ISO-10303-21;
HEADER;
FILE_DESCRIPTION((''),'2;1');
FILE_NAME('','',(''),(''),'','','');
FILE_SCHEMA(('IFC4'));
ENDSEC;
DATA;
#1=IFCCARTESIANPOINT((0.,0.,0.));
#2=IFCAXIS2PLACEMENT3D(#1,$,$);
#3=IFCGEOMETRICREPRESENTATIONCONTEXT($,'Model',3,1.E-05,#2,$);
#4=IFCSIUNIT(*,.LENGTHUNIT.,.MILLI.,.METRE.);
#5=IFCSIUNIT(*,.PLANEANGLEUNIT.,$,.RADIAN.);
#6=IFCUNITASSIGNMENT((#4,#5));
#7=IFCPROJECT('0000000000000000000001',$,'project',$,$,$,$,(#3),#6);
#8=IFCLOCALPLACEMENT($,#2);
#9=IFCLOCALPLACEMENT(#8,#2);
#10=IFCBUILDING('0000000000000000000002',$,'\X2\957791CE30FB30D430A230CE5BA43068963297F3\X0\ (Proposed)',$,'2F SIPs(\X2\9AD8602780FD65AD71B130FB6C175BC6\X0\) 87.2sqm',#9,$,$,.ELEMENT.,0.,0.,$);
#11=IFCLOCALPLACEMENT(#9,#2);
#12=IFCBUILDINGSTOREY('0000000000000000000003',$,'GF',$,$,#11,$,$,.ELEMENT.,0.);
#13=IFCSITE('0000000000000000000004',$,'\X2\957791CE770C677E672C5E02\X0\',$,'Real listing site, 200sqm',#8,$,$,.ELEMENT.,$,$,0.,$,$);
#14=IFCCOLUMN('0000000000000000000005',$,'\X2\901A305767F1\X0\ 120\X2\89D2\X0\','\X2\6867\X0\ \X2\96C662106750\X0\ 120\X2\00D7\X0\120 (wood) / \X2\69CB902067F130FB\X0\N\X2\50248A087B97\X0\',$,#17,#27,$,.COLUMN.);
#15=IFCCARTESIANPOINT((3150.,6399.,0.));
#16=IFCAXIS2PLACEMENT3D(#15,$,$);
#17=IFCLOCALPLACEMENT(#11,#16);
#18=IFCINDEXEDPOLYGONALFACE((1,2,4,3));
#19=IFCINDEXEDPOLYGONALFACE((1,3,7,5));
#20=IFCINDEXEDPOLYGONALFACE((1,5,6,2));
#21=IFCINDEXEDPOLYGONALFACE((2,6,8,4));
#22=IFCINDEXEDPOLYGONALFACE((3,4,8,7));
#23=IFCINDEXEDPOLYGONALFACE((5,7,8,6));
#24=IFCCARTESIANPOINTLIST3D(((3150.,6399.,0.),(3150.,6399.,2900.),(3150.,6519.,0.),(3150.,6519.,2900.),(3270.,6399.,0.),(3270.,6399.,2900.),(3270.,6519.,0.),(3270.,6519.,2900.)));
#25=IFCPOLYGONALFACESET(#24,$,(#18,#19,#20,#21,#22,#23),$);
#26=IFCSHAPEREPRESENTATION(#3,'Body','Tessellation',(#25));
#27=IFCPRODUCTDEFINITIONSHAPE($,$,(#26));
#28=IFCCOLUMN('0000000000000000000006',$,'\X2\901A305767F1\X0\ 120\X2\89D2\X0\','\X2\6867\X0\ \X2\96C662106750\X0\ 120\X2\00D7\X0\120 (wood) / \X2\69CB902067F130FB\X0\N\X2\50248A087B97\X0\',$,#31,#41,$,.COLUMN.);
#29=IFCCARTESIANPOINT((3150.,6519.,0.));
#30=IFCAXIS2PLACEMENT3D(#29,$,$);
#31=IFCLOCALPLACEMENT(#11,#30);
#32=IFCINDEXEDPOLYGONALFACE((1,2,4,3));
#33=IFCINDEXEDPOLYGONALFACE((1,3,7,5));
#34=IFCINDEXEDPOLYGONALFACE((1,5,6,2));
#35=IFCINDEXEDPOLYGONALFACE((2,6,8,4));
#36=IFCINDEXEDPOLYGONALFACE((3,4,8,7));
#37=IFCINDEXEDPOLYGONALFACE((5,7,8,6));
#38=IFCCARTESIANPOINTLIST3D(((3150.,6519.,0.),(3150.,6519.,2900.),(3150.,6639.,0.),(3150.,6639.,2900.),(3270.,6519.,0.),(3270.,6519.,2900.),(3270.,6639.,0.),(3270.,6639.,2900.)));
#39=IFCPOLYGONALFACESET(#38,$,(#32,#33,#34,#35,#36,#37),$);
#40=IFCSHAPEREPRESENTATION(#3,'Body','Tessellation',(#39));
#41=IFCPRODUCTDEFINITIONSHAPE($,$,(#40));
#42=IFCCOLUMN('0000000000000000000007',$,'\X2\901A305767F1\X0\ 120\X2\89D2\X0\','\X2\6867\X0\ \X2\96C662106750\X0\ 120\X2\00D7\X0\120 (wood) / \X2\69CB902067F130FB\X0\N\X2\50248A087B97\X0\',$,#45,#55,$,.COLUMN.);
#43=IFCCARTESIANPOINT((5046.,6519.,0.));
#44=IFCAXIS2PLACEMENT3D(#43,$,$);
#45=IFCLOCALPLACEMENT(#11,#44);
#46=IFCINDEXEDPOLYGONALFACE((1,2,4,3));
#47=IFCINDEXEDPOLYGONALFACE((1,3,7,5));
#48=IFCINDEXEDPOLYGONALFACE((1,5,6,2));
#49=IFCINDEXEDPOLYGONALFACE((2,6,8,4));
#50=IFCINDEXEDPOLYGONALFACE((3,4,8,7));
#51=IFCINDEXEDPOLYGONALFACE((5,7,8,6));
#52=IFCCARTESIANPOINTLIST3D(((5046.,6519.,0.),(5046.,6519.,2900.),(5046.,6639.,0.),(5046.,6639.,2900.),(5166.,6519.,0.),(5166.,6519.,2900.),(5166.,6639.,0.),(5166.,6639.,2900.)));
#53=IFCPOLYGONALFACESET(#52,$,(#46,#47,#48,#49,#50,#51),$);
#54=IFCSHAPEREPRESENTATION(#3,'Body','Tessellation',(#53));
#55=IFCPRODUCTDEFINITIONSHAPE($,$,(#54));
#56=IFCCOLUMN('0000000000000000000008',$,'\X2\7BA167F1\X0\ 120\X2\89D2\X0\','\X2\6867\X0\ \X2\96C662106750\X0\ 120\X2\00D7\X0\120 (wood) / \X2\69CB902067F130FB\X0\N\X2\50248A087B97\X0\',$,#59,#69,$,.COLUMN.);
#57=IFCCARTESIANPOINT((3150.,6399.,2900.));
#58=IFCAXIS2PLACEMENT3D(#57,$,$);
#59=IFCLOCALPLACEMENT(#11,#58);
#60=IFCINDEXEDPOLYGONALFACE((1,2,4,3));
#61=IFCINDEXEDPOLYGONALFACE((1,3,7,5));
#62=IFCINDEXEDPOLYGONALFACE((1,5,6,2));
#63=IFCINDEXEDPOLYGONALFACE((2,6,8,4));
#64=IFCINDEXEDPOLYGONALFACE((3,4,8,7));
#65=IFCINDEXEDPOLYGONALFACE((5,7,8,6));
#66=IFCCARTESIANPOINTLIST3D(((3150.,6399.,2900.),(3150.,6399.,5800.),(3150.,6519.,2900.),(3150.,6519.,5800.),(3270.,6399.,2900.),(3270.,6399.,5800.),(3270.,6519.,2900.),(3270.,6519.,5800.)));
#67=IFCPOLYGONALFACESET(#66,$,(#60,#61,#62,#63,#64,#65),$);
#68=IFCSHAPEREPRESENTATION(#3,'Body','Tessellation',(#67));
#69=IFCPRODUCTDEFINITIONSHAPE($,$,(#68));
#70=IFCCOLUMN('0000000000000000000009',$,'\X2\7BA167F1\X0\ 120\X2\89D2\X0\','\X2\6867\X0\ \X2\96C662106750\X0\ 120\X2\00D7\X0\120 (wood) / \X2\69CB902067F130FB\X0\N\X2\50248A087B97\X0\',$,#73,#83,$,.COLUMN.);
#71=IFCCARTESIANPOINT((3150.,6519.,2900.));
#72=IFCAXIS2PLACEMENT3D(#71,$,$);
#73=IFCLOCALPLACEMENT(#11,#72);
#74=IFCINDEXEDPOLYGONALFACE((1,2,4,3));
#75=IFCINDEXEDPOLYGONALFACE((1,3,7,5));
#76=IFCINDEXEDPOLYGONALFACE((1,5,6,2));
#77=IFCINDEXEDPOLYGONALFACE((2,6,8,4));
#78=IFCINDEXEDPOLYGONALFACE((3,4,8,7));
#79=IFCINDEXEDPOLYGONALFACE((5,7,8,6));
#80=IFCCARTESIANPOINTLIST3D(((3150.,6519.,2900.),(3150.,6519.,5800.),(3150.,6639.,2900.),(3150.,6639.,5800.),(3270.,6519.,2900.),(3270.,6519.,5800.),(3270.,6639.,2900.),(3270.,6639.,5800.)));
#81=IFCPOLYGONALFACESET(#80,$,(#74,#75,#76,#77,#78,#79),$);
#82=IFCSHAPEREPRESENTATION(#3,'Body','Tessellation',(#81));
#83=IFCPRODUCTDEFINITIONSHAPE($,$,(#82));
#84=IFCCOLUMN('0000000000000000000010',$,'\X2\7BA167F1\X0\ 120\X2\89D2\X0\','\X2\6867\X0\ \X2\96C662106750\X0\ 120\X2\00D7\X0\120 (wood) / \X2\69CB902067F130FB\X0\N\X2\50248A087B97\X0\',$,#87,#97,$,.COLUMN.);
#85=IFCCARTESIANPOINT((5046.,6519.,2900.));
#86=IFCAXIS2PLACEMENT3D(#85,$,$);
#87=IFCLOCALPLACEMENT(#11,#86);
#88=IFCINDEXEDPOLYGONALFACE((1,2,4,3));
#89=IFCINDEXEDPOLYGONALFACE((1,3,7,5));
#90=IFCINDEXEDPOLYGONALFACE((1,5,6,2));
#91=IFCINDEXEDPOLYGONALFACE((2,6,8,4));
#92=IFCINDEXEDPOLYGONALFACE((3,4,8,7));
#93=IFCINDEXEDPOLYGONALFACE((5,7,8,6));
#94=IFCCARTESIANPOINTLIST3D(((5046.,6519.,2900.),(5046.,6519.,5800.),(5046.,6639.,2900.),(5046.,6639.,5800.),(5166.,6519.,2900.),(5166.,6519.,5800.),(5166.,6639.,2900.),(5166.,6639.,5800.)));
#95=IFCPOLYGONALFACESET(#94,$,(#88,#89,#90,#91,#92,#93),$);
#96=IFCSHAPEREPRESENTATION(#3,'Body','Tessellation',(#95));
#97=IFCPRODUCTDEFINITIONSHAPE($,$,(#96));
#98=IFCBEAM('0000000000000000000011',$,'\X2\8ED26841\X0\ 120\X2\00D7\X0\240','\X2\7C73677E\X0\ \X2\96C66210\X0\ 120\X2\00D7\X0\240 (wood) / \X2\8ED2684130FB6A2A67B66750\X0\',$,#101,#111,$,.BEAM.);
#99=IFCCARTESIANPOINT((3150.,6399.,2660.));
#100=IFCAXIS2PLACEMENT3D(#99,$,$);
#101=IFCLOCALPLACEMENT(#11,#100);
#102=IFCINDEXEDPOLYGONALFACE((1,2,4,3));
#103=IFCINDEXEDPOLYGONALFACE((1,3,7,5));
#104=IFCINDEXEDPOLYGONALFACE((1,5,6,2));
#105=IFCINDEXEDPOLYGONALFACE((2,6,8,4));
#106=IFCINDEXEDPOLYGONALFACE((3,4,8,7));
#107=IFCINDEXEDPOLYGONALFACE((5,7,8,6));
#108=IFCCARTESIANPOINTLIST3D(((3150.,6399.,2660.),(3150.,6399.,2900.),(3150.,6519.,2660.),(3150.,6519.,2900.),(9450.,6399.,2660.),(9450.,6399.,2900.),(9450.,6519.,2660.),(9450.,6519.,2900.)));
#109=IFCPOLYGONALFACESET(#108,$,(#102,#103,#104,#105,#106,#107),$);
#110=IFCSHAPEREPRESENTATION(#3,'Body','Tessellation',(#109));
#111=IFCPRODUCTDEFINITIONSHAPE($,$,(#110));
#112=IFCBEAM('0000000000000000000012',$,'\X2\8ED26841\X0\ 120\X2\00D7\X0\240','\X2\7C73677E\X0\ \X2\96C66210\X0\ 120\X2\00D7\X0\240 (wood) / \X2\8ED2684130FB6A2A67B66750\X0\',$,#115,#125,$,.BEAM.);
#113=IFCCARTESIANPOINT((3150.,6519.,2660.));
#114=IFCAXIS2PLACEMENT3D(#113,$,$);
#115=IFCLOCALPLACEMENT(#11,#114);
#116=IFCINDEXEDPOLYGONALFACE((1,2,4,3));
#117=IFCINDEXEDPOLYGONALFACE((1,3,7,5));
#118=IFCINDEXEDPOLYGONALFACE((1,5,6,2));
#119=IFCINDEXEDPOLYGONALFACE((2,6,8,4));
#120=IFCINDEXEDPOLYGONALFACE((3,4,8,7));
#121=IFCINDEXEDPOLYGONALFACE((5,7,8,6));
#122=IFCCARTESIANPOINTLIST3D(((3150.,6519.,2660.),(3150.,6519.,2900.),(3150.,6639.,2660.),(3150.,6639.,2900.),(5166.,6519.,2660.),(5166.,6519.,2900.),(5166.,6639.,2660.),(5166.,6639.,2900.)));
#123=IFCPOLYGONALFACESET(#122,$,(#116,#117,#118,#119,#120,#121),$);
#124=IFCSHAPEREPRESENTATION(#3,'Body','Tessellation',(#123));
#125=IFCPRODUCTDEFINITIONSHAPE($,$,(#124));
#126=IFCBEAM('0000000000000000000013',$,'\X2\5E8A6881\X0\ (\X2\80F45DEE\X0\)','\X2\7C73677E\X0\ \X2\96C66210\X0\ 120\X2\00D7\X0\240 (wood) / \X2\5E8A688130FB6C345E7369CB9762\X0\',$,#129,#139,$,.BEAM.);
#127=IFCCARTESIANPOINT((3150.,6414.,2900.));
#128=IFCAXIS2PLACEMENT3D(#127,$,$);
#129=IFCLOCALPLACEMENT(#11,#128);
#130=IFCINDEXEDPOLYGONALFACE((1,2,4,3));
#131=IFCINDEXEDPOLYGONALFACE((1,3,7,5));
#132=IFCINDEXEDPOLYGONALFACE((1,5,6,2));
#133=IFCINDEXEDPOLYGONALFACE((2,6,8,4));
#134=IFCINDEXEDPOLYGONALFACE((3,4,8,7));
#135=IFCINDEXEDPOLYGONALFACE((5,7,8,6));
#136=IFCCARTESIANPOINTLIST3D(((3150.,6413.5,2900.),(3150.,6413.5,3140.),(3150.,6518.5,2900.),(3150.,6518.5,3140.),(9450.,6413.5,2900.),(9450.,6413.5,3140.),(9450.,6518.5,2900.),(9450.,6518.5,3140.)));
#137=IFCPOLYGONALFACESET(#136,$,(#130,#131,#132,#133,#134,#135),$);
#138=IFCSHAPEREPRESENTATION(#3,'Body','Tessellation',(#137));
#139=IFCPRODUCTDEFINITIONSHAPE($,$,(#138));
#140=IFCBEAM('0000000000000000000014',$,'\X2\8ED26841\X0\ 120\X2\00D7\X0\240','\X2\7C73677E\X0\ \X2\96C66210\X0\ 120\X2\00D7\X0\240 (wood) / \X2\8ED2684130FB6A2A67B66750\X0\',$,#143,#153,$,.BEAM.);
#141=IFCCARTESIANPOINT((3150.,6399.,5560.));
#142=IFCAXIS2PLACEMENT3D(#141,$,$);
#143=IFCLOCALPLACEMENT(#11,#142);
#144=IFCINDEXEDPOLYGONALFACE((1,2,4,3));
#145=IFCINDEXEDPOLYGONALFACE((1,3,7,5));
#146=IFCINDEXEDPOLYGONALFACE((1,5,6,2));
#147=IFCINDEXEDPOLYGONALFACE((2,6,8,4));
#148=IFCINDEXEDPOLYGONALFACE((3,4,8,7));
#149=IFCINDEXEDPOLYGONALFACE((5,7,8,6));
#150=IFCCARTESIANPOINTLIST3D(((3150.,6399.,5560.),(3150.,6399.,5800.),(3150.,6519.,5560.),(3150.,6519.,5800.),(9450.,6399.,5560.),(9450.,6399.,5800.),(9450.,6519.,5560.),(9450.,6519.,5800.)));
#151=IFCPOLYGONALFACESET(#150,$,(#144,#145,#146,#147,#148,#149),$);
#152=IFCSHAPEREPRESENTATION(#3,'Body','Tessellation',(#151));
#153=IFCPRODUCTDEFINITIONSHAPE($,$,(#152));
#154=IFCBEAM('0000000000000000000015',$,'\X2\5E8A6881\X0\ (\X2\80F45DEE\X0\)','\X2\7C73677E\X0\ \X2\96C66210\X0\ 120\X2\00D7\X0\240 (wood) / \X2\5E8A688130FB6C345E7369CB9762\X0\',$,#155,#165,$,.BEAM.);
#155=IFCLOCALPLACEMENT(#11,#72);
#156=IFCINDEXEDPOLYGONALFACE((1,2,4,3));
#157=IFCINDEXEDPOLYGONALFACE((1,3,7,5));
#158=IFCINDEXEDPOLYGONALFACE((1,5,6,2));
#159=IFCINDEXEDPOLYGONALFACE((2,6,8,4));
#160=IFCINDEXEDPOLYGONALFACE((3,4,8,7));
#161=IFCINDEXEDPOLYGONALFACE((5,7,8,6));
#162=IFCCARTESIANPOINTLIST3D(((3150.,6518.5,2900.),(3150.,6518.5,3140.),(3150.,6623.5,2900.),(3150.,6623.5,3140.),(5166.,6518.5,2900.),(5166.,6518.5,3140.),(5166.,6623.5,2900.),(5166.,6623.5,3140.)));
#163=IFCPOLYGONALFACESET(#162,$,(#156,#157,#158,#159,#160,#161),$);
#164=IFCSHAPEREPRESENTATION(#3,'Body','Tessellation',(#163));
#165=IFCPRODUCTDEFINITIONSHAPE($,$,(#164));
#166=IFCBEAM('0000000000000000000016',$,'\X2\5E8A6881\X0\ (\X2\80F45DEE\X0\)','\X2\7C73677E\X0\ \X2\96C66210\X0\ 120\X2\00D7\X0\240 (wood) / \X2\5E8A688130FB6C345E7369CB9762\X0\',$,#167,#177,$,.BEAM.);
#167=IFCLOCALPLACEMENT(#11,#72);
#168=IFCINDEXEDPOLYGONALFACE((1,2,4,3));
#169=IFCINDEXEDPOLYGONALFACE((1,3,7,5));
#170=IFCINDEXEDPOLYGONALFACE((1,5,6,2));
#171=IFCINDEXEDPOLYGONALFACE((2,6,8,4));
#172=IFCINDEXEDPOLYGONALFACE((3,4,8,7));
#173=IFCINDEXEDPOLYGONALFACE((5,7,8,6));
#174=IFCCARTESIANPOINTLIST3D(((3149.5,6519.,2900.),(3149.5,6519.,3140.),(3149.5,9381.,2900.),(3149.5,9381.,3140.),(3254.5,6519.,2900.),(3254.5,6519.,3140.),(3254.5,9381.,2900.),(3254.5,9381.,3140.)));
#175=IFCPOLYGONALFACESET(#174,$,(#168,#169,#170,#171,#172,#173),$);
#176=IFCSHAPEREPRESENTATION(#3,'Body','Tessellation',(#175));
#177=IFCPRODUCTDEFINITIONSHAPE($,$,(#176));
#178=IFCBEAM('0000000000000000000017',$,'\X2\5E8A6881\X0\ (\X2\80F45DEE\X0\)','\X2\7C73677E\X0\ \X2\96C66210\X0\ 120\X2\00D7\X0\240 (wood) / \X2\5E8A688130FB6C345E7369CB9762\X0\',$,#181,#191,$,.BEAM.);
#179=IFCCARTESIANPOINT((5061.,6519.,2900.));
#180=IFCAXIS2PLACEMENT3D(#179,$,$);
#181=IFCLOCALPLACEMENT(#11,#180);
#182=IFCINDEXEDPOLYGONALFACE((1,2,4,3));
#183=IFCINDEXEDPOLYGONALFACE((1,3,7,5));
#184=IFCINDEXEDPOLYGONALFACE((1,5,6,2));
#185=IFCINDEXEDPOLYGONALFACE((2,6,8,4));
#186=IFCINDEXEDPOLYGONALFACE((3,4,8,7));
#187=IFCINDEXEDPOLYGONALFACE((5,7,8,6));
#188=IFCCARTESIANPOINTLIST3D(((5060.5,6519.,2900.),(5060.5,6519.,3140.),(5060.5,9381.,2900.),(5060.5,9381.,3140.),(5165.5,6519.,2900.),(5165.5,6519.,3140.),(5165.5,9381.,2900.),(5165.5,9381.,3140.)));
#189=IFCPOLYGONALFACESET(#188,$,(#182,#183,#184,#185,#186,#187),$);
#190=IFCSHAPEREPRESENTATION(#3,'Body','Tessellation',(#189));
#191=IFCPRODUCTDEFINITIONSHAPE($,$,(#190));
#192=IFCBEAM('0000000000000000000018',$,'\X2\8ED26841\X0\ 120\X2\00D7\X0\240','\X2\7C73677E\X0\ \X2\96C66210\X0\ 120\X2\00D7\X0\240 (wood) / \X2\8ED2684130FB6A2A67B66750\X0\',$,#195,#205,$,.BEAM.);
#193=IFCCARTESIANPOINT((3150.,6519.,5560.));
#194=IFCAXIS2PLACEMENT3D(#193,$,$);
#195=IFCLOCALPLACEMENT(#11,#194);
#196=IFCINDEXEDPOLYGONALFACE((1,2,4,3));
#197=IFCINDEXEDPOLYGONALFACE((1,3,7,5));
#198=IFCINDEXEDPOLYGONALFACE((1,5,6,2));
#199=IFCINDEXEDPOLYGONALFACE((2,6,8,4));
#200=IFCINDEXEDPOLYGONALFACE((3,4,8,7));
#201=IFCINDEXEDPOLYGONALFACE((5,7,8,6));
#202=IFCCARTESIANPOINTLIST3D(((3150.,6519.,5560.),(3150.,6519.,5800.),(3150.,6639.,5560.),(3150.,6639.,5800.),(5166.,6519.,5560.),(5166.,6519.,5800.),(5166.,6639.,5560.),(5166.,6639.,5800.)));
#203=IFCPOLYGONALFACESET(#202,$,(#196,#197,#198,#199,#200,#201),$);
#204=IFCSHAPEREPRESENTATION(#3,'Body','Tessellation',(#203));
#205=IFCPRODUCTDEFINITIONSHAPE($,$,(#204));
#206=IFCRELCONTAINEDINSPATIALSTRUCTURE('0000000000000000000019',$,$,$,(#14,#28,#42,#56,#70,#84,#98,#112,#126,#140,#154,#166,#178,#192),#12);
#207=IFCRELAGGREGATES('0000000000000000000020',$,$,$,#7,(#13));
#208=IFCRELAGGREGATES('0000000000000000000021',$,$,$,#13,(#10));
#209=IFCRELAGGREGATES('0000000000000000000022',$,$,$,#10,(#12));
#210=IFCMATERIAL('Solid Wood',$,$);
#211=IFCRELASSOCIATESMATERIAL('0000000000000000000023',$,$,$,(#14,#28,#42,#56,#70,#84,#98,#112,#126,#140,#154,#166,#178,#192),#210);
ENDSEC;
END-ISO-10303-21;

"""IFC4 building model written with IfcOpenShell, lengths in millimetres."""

from ifc_helpers import new_model, si_unit, frame, frame_2d, origin, place, context, project, spatial, rectangle, extrude, material, element, save


model = new_model("IFC4")

# Units and contexts
model_context = context("Model", 3, precision=1e-05, world=origin())
ifc_project = project(units=[si_unit("LENGTHUNIT", "METRE", prefix="MILLI"), si_unit("PLANEANGLEUNIT", "RADIAN")], contexts=[model_context])

# Site, building, storey
site_placement = place(None, origin())
site = spatial("IfcSite", under=ifc_project, at=site_placement, Name="長野県松本市", ObjectType="Real listing site, 200sqm", CompositionType="ELEMENT", RefElevation=0.0)
building_placement = place(site_placement, origin())
building = spatial("IfcBuilding", under=site, at=building_placement, Name="長野・ピアノ室と防音 (Proposed)", ObjectType="2F SIPs(高性能断熱・気密) 87.2sqm", CompositionType="ELEMENT", ElevationOfRefHeight=0.0, ElevationOfTerrain=0.0)
storey_placement = place(building_placement, origin())
storey = spatial("IfcBuildingStorey", under=building, at=storey_placement, Name="GF", CompositionType="ELEMENT", Elevation=0.0)

# Columns
ifc_material_1 = material(Name="Solid Wood")
column_1_placement = place(storey_placement, frame((3150.0, 6399.0, 0.0)))
element("IfcColumn", 1, at=column_1_placement, inside=storey, material=ifc_material_1, Name="通し柱 120角", Description="桧 集成材 120×120 (wood) / 構造柱・N値計算", PredefinedType="COLUMN", context=model_context, shape_type="SweptSolid", body=[
    extrude(rectangle(XDim=120.0, YDim=120.0, at=frame_2d((60.0, 60.0))), frame((3150.0, 6399.0, 0.0)), (0.0, 0.0, 1.0), 2900.0),
])
column_2_placement = place(storey_placement, frame((3150.0, 6519.0, 0.0)))
element("IfcColumn", 2, at=column_2_placement, inside=storey, material=ifc_material_1, Name="通し柱 120角", Description="桧 集成材 120×120 (wood) / 構造柱・N値計算", PredefinedType="COLUMN", context=model_context, shape_type="SweptSolid", body=[
    extrude(rectangle(XDim=120.0, YDim=120.0, at=frame_2d((60.0, 60.0))), frame((3150.0, 6519.0, 0.0)), (0.0, 0.0, 1.0), 2900.0),
])
column_3_placement = place(storey_placement, frame((5046.0, 6519.0, 0.0)))
element("IfcColumn", 3, at=column_3_placement, inside=storey, material=ifc_material_1, Name="通し柱 120角", Description="桧 集成材 120×120 (wood) / 構造柱・N値計算", PredefinedType="COLUMN", context=model_context, shape_type="SweptSolid", body=[
    extrude(rectangle(XDim=120.0, YDim=120.0, at=frame_2d((60.0, 60.0))), frame((5046.0, 6519.0, 0.0)), (0.0, 0.0, 1.0), 2900.0),
])
column_4_placement = place(storey_placement, frame((3150.0, 6399.0, 2900.0)))
element("IfcColumn", 4, at=column_4_placement, inside=storey, material=ifc_material_1, Name="管柱 120角", Description="桧 集成材 120×120 (wood) / 構造柱・N値計算", PredefinedType="COLUMN", context=model_context, shape_type="SweptSolid", body=[
    extrude(rectangle(XDim=120.0, YDim=120.0, at=frame_2d((60.0, 60.0))), frame((3150.0, 6399.0, 2900.0)), (0.0, 0.0, 1.0), 2900.0),
])
column_5_placement = place(storey_placement, frame((3150.0, 6519.0, 2900.0)))
element("IfcColumn", 5, at=column_5_placement, inside=storey, material=ifc_material_1, Name="管柱 120角", Description="桧 集成材 120×120 (wood) / 構造柱・N値計算", PredefinedType="COLUMN", context=model_context, shape_type="SweptSolid", body=[
    extrude(rectangle(XDim=120.0, YDim=120.0, at=frame_2d((60.0, 60.0))), frame((3150.0, 6519.0, 2900.0)), (0.0, 0.0, 1.0), 2900.0),
])
column_6_placement = place(storey_placement, frame((5046.0, 6519.0, 2900.0)))
element("IfcColumn", 6, at=column_6_placement, inside=storey, material=ifc_material_1, Name="管柱 120角", Description="桧 集成材 120×120 (wood) / 構造柱・N値計算", PredefinedType="COLUMN", context=model_context, shape_type="SweptSolid", body=[
    extrude(rectangle(XDim=120.0, YDim=120.0, at=frame_2d((60.0, 60.0))), frame((5046.0, 6519.0, 2900.0)), (0.0, 0.0, 1.0), 2900.0),
])

# Beams
beam_1_placement = place(storey_placement, frame((3150.0, 6399.0, 2660.0)))
element("IfcBeam", 7, at=beam_1_placement, inside=storey, material=ifc_material_1, Name="軒桁 120×240", Description="米松 集成 120×240 (wood) / 軒桁・横架材", PredefinedType="BEAM", context=model_context, shape_type="SweptSolid", body=[
    extrude(rectangle(XDim=6300.0, YDim=120.0, at=frame_2d((3150.0, 60.0))), frame((3150.0, 6399.0, 2660.0)), (0.0, 0.0, 1.0), 240.0),
])
beam_2_placement = place(storey_placement, frame((3150.0, 6519.0, 2660.0)))
element("IfcBeam", 8, at=beam_2_placement, inside=storey, material=ifc_material_1, Name="軒桁 120×240", Description="米松 集成 120×240 (wood) / 軒桁・横架材", PredefinedType="BEAM", context=model_context, shape_type="SweptSolid", body=[
    extrude(rectangle(XDim=2016.0, YDim=120.0, at=frame_2d((1008.0, 60.0))), frame((3150.0, 6519.0, 2660.0)), (0.0, 0.0, 1.0), 240.0),
])
beam_3_placement = place(storey_placement, frame((3150.0, 6414.0, 2900.0)))
element("IfcBeam", 9, at=beam_3_placement, inside=storey, material=ifc_material_1, Name="床梁 (胴差)", Description="米松 集成 120×240 (wood) / 床梁・水平構面", PredefinedType="BEAM", context=model_context, shape_type="SweptSolid", body=[
    extrude(rectangle(XDim=6300.0, YDim=105.0, at=frame_2d((3150.0, 52.0))), frame((3150.0, 6414.0, 2900.0)), (0.0, 0.0, 1.0), 240.0),
])
beam_4_placement = place(storey_placement, frame((3150.0, 6399.0, 5560.0)))
element("IfcBeam", 10, at=beam_4_placement, inside=storey, material=ifc_material_1, Name="軒桁 120×240", Description="米松 集成 120×240 (wood) / 軒桁・横架材", PredefinedType="BEAM", context=model_context, shape_type="SweptSolid", body=[
    extrude(rectangle(XDim=6300.0, YDim=120.0, at=frame_2d((3150.0, 60.0))), frame((3150.0, 6399.0, 5560.0)), (0.0, 0.0, 1.0), 240.0),
])
beam_5_placement = place(storey_placement, frame((3150.0, 6519.0, 2900.0)))
element("IfcBeam", 11, at=beam_5_placement, inside=storey, material=ifc_material_1, Name="床梁 (胴差)", Description="米松 集成 120×240 (wood) / 床梁・水平構面", PredefinedType="BEAM", context=model_context, shape_type="SweptSolid", body=[
    extrude(rectangle(XDim=2016.0, YDim=105.0, at=frame_2d((1008.0, 52.0))), frame((3150.0, 6519.0, 2900.0)), (0.0, 0.0, 1.0), 240.0),
])
beam_6_placement = place(storey_placement, frame((3150.0, 6519.0, 2900.0)))
element("IfcBeam", 12, at=beam_6_placement, inside=storey, material=ifc_material_1, Name="床梁 (胴差)", Description="米松 集成 120×240 (wood) / 床梁・水平構面", PredefinedType="BEAM", context=model_context, shape_type="SweptSolid", body=[
    extrude(rectangle(XDim=105.0, YDim=2862.0, at=frame_2d((52.0, 1431.0))), frame((3150.0, 6519.0, 2900.0)), (0.0, 0.0, 1.0), 240.0),
])
beam_7_placement = place(storey_placement, frame((5061.0, 6519.0, 2900.0)))
element("IfcBeam", 13, at=beam_7_placement, inside=storey, material=ifc_material_1, Name="床梁 (胴差)", Description="米松 集成 120×240 (wood) / 床梁・水平構面", PredefinedType="BEAM", context=model_context, shape_type="SweptSolid", body=[
    extrude(rectangle(XDim=105.0, YDim=2862.0, at=frame_2d((52.0, 1431.0))), frame((5061.0, 6519.0, 2900.0)), (0.0, 0.0, 1.0), 240.0),
])
beam_8_placement = place(storey_placement, frame((3150.0, 6519.0, 5560.0)))
element("IfcBeam", 14, at=beam_8_placement, inside=storey, material=ifc_material_1, Name="軒桁 120×240", Description="米松 集成 120×240 (wood) / 軒桁・横架材", PredefinedType="BEAM", context=model_context, shape_type="SweptSolid", body=[
    extrude(rectangle(XDim=2016.0, YDim=120.0, at=frame_2d((1008.0, 60.0))), frame((3150.0, 6519.0, 5560.0)), (0.0, 0.0, 1.0), 240.0),
])

save(model, "model.ifc")
